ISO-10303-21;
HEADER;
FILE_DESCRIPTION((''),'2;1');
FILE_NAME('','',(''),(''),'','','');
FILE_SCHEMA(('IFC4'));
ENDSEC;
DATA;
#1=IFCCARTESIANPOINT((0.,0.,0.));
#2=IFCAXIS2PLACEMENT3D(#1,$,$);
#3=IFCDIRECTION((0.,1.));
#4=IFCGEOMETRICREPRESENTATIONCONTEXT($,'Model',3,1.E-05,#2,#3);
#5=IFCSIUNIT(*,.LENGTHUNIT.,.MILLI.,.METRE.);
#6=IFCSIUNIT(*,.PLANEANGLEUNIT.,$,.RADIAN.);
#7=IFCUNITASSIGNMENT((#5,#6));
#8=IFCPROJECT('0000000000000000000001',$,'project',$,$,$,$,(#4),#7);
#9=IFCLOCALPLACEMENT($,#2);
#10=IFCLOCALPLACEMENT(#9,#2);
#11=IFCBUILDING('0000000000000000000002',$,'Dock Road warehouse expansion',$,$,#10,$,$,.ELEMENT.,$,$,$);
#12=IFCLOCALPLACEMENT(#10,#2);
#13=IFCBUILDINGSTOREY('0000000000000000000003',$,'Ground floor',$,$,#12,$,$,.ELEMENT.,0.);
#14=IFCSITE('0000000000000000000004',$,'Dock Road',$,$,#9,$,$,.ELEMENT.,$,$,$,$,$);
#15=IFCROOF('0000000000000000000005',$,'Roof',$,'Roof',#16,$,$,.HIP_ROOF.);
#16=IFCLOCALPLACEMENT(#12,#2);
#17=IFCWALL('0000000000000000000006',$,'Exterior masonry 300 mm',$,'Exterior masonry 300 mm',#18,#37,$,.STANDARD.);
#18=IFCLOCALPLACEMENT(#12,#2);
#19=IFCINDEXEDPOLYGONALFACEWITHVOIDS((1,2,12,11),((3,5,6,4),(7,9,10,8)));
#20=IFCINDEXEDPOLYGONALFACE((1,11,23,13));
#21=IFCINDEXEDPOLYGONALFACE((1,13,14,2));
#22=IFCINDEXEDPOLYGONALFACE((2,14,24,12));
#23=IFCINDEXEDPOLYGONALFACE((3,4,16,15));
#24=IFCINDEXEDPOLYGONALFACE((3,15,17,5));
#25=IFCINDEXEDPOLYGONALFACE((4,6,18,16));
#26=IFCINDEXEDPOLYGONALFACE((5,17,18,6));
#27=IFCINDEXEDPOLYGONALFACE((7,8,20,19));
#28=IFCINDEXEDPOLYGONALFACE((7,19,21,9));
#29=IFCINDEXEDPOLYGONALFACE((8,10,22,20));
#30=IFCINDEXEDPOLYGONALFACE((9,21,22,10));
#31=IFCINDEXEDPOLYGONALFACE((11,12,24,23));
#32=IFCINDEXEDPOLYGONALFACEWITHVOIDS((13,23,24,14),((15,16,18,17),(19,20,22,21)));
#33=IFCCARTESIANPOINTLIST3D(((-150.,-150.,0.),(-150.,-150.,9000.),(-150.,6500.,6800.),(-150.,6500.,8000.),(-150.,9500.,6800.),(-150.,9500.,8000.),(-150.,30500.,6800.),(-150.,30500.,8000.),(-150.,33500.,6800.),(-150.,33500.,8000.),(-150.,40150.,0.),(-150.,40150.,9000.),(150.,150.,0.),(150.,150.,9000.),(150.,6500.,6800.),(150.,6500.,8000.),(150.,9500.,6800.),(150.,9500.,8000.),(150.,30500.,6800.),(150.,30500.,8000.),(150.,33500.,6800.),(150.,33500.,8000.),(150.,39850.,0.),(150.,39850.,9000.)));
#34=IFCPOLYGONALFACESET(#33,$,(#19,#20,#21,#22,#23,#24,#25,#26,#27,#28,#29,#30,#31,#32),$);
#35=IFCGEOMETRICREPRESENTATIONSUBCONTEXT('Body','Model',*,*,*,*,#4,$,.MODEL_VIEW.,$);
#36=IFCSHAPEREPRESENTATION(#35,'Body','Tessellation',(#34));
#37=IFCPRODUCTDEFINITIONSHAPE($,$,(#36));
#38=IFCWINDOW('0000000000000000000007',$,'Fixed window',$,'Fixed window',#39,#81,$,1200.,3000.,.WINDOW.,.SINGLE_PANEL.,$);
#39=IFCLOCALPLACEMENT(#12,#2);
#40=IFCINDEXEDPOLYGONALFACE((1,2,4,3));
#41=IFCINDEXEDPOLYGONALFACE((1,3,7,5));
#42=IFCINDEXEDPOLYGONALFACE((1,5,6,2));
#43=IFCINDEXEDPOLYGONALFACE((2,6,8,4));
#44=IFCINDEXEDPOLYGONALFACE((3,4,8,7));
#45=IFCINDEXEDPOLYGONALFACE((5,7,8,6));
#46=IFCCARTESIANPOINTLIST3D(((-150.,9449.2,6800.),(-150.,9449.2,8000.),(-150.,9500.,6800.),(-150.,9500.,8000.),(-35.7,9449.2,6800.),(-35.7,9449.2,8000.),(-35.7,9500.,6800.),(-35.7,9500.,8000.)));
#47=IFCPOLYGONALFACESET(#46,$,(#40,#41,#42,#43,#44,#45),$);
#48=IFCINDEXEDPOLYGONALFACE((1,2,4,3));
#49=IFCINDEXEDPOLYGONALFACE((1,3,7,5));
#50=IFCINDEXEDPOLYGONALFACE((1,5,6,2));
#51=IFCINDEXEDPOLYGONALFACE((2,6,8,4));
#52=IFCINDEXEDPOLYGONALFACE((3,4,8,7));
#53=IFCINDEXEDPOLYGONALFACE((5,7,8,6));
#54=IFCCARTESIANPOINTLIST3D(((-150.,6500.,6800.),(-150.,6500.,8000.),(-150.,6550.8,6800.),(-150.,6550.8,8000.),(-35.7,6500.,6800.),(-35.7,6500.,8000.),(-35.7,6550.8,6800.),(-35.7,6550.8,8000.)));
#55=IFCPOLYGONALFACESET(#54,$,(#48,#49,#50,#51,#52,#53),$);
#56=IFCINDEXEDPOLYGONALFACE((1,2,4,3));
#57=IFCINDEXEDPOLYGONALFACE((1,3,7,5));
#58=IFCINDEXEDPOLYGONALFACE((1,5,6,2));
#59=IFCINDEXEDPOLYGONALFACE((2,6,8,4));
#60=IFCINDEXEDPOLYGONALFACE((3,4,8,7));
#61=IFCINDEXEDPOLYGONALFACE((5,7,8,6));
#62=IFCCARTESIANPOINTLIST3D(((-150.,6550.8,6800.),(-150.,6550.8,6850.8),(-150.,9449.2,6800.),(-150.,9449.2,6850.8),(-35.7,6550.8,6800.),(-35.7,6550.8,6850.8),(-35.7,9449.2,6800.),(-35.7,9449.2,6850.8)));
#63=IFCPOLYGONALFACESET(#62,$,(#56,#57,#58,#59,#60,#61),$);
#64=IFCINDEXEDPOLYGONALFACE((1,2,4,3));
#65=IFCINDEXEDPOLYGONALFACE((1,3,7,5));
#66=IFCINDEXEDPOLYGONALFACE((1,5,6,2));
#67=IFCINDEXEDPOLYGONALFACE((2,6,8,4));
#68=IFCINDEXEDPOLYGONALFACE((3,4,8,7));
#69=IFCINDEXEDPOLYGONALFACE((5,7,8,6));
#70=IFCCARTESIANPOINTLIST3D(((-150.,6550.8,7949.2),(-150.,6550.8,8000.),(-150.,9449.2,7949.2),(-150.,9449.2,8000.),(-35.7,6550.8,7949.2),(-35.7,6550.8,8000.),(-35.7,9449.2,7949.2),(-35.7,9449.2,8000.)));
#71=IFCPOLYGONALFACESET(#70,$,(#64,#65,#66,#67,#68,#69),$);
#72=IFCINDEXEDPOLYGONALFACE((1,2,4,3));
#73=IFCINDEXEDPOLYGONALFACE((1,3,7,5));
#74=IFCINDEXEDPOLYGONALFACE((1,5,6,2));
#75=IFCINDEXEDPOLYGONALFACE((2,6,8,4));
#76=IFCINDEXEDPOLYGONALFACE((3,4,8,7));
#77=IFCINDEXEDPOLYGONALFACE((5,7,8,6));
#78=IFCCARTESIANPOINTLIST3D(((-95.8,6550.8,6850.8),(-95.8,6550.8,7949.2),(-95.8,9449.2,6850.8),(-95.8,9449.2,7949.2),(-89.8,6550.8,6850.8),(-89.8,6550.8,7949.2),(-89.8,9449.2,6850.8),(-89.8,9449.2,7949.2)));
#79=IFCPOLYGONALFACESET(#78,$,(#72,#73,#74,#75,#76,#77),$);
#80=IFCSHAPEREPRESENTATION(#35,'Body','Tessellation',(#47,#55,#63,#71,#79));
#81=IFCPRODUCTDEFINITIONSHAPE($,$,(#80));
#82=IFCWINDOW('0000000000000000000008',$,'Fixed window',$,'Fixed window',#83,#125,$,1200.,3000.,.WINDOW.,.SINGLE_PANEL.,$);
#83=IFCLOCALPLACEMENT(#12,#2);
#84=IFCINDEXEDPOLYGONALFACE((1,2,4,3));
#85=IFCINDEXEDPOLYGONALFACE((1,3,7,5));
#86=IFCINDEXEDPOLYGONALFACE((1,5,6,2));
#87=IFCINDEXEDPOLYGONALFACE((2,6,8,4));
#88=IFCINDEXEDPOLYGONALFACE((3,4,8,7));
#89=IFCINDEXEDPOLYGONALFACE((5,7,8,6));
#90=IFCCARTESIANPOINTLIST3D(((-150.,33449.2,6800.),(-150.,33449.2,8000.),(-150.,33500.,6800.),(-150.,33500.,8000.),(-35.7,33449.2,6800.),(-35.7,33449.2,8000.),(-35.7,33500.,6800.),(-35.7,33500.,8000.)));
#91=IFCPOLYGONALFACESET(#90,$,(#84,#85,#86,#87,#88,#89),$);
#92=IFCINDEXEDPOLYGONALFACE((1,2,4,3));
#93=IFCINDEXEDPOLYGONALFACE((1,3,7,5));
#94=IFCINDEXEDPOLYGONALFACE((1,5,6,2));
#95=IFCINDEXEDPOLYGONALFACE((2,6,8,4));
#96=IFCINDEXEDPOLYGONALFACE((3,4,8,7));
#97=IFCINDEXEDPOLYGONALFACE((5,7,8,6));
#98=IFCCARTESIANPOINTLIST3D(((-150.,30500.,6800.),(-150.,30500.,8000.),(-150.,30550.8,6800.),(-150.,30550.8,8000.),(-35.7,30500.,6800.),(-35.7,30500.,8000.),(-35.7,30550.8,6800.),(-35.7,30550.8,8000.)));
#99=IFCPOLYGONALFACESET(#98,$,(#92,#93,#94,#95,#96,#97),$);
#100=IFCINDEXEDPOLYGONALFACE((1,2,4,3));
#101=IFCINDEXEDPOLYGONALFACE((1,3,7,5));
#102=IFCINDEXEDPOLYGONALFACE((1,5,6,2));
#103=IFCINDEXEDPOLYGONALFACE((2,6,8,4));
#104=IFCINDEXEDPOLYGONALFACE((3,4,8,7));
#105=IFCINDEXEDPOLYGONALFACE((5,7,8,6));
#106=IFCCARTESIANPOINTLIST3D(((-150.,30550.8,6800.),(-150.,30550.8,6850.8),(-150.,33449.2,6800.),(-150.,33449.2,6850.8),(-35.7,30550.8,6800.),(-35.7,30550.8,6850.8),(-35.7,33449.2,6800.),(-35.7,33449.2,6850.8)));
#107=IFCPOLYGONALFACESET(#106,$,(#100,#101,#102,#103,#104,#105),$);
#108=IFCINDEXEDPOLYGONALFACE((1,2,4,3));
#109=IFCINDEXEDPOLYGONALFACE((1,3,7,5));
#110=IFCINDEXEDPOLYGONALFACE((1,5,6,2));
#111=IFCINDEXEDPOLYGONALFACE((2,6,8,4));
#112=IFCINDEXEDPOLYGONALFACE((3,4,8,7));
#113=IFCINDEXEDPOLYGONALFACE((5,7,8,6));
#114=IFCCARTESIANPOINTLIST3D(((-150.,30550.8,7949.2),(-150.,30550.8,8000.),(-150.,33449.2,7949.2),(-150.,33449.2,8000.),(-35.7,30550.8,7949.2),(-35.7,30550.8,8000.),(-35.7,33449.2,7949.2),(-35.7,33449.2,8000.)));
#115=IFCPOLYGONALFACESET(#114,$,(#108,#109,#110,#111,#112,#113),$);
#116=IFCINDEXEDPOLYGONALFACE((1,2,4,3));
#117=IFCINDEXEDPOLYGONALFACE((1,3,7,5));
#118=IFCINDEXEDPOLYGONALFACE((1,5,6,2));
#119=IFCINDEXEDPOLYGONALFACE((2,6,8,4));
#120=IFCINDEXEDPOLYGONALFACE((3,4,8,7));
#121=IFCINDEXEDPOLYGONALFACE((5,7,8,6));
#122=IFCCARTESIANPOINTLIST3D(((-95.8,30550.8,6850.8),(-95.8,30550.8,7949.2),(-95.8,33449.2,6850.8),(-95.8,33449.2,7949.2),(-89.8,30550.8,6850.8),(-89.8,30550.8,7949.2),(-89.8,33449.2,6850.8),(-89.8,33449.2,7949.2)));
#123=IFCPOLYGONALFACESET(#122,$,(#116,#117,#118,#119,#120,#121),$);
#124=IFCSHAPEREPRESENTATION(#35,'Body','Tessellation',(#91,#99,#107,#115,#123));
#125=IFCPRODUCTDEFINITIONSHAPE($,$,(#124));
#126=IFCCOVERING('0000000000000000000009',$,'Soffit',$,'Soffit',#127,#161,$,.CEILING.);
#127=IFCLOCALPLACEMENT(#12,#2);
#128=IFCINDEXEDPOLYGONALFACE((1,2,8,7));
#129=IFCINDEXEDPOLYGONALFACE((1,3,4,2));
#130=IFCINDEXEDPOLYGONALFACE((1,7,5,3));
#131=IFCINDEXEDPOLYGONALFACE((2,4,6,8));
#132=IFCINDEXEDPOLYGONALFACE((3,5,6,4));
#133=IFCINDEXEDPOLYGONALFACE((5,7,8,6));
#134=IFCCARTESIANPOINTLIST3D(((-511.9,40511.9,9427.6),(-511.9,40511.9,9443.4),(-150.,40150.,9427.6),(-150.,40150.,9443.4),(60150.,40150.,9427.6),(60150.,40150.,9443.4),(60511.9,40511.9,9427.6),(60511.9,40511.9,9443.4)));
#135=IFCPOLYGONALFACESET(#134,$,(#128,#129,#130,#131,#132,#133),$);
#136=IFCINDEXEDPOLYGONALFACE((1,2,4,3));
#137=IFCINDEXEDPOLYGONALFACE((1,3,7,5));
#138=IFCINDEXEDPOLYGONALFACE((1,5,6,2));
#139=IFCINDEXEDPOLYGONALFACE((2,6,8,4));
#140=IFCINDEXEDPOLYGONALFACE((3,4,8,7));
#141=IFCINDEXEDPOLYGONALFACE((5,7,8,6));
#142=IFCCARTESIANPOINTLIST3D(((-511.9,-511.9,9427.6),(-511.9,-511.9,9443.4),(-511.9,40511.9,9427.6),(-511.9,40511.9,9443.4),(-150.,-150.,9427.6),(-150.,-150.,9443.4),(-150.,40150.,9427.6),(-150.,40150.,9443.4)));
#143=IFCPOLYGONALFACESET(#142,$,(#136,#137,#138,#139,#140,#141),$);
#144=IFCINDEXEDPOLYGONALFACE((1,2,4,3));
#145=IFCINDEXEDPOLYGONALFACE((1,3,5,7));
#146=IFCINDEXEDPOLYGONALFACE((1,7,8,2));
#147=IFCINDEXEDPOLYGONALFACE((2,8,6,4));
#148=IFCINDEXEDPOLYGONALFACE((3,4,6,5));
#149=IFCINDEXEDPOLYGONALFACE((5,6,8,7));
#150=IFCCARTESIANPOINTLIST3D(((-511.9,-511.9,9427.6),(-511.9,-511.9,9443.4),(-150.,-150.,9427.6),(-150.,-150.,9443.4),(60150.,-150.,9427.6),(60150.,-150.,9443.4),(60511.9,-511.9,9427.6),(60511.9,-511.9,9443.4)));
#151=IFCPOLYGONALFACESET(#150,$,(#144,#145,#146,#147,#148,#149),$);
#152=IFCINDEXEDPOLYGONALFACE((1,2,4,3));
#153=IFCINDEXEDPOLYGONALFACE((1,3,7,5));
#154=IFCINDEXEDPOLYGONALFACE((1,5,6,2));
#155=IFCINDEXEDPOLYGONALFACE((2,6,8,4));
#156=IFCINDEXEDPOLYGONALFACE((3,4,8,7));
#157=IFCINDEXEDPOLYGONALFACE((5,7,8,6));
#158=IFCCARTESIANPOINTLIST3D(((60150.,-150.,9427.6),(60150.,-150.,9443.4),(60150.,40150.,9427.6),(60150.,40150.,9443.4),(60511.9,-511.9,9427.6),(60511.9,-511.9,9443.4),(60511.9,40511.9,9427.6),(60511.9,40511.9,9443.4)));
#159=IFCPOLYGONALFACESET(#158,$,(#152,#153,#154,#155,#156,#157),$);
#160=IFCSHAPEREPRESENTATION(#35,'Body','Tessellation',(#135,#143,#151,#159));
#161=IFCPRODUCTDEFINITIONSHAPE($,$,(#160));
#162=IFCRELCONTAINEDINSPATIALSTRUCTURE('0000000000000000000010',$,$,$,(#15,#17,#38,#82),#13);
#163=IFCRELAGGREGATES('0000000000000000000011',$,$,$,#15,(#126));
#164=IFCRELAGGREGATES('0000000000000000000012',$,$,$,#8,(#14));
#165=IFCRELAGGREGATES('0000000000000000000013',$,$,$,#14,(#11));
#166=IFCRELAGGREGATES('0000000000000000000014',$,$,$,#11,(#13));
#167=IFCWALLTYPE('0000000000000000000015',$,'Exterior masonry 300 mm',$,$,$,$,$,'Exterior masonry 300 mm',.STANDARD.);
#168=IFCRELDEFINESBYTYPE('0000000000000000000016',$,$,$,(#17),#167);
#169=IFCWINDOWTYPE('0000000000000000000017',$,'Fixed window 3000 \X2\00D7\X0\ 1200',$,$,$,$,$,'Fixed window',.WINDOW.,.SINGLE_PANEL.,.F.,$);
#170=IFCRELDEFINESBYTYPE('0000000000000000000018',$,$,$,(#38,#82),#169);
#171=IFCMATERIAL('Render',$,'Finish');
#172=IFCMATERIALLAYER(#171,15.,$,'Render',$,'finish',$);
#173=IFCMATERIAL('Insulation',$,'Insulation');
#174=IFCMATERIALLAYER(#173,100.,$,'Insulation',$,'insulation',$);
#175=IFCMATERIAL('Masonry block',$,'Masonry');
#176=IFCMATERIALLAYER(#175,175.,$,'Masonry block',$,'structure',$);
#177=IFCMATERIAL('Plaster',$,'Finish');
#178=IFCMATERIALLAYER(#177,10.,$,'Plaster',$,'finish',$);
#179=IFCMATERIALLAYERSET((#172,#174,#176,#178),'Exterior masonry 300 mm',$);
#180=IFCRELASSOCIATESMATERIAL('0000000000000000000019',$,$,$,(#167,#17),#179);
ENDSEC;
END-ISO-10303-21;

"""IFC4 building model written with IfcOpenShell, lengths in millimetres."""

from ifc_helpers import new_model, si_unit, direction, frame, origin, origin_with_axes, place, context, subcontext, project, spatial, polyline, outline, extrude, material, layer, layer_set, layer_usage, type_object, element, fill, aggregate, save


model = new_model("IFC4")

# Units and contexts
model_context = context("Model", 3, precision=1e-05, world=origin(), true_north=direction((0.0, 1.0)))
body_context = subcontext(model_context, "Body", "Model", "MODEL_VIEW")
ifc_project = project(units=[si_unit("LENGTHUNIT", "METRE", prefix="MILLI"), si_unit("PLANEANGLEUNIT", "RADIAN")], contexts=[model_context])

# Site, building, storey
site_placement = place(None, origin())
site = spatial("IfcSite", under=ifc_project, at=site_placement, Name="Dock Road", CompositionType="ELEMENT")
building_placement = place(site_placement, origin())
building = spatial("IfcBuilding", under=site, at=building_placement, Name="Dock Road warehouse expansion", CompositionType="ELEMENT")
storey_placement = place(building_placement, origin())
storey = spatial("IfcBuildingStorey", under=building, at=storey_placement, Name="Ground floor", CompositionType="ELEMENT", Elevation=0.0)

# Roof
roof_placement = place(storey_placement, origin_with_axes())
roof = element("IfcRoof", 1, at=roof_placement, inside=storey, Name="Roof", ObjectType="Roof", PredefinedType="HIP_ROOF")

# Shared definitions
ifc_material_1 = material(Name="Render", Category="Finish")
ifc_layer_1 = layer(ifc_material_1, 15.0, Name="Render", Category="finish")
ifc_material_2 = material(Name="Insulation", Category="Insulation")
ifc_layer_2 = layer(ifc_material_2, 100.0, Name="Insulation", Category="insulation")
ifc_material_3 = material(Name="Masonry block", Category="Masonry")
ifc_layer_3 = layer(ifc_material_3, 175.0, Name="Masonry block", Category="structure")
ifc_material_4 = material(Name="Plaster", Category="Finish")
ifc_layer_4 = layer(ifc_material_4, 10.0, Name="Plaster", Category="finish")
ifc_layer_set = layer_set([ifc_layer_1, ifc_layer_2, ifc_layer_3, ifc_layer_4], Name="Exterior masonry 300 mm")
wall_type = type_object("IfcWallType", Name="Exterior masonry 300 mm", ElementType="Exterior masonry 300 mm", PredefinedType="STANDARD", material=ifc_layer_set)
window_type = type_object("IfcWindowType", Name="Fixed window 3000 × 1200", ElementType="Fixed window", ParameterTakesPrecedence=False, PartitioningType="SINGLE_PANEL", PredefinedType="WINDOW")

# Wall, openings, windows
ifc_layer_usage_1 = layer_usage(ifc_layer_set, "AXIS2", "POSITIVE", -150.0)
wall_1_placement = place(storey_placement, frame((0.0, 40000.0, 0.0), z_axis=(0.0, 0.0, 1.0), x_axis=(0.0, -1.0, 0.0)))
wall_1 = element("IfcWall", 2, at=wall_1_placement, inside=storey, type_object=wall_type, material=ifc_layer_usage_1, Name="Exterior masonry 300 mm", ObjectType="Exterior masonry 300 mm", PredefinedType="STANDARD", context=body_context, shape_type="SweptSolid", body=[
    extrude(outline(polyline([(-150.0, -150.0), (40150.0, -150.0), (39850.0, 150.0), (150.0, 150.0), (-150.0, -150.0)])), origin(), (0.0, 0.0, 1.0), 9000.0),
])
opening_1_placement = place(wall_1_placement, frame((30500.0, 0.0, 6800.0), z_axis=(0.0, 0.0, 1.0), x_axis=(1.0, 0.0, 0.0)))
opening_1 = element("IfcOpeningElement", 3, at=opening_1_placement, cuts=wall_1, PredefinedType="OPENING", context=body_context, shape_type="SweptSolid", body=[
    extrude(outline(polyline([(0.0, -160.0), (3000.0, -160.0), (3000.0, 160.0), (0.0, 160.0), (0.0, -160.0)])), origin(), (0.0, 0.0, 1.0), 1200.0),
])
opening_2_placement = place(wall_1_placement, frame((6500.0, 0.0, 6800.0), z_axis=(0.0, 0.0, 1.0), x_axis=(1.0, 0.0, 0.0)))
opening_2 = element("IfcOpeningElement", 4, at=opening_2_placement, cuts=wall_1, PredefinedType="OPENING", context=body_context, shape_type="SweptSolid", body=[
    extrude(outline(polyline([(0.0, -160.0), (3000.0, -160.0), (3000.0, 160.0), (0.0, 160.0), (0.0, -160.0)])), origin(), (0.0, 0.0, 1.0), 1200.0),
])
window_1_placement = place(opening_1_placement, origin_with_axes())
window_1 = element("IfcWindow", 5, at=window_1_placement, inside=storey, type_object=window_type, Name="Fixed window", ObjectType="Fixed window", OverallHeight=1200.0, OverallWidth=3000.0, PartitioningType="SINGLE_PANEL", PredefinedType="WINDOW", context=body_context, shape_type="SweptSolid", body=[
    extrude(outline(polyline([(0.0, -150.0), (50.8, -150.0), (50.8, -35.7), (0.0, -35.7), (0.0, -150.0)])), origin(), (0.0, 0.0, 1.0), 1200.0),
    extrude(outline(polyline([(2949.2, -150.0), (3000.0, -150.0), (3000.0, -35.7), (2949.2, -35.7), (2949.2, -150.0)])), origin(), (0.0, 0.0, 1.0), 1200.0),
    extrude(outline(polyline([(50.8, -150.0), (2949.2, -150.0), (2949.2, -35.7), (50.8, -35.7), (50.8, -150.0)])), origin(), (0.0, 0.0, 1.0), 50.8),
    extrude(outline(polyline([(50.8, -150.0), (2949.2, -150.0), (2949.2, -35.7), (50.8, -35.7), (50.8, -150.0)])), frame((0.0, 0.0, 1149.2)), (0.0, 0.0, 1.0), 50.8),
    extrude(outline(polyline([(50.8, -95.8), (2949.2, -95.8), (2949.2, -89.8), (50.8, -89.8), (50.8, -95.8)])), frame((0.0, 0.0, 50.8)), (0.0, 0.0, 1.0), 1098.4),
])
fill(opening_1, window_1)
window_2_placement = place(opening_2_placement, origin_with_axes())
window_2 = element("IfcWindow", 6, at=window_2_placement, inside=storey, type_object=window_type, Name="Fixed window", ObjectType="Fixed window", OverallHeight=1200.0, OverallWidth=3000.0, PartitioningType="SINGLE_PANEL", PredefinedType="WINDOW", context=body_context, shape_type="SweptSolid", body=[
    extrude(outline(polyline([(0.0, -150.0), (50.8, -150.0), (50.8, -35.7), (0.0, -35.7), (0.0, -150.0)])), origin(), (0.0, 0.0, 1.0), 1200.0),
    extrude(outline(polyline([(2949.2, -150.0), (3000.0, -150.0), (3000.0, -35.7), (2949.2, -35.7), (2949.2, -150.0)])), origin(), (0.0, 0.0, 1.0), 1200.0),
    extrude(outline(polyline([(50.8, -150.0), (2949.2, -150.0), (2949.2, -35.7), (50.8, -35.7), (50.8, -150.0)])), origin(), (0.0, 0.0, 1.0), 50.8),
    extrude(outline(polyline([(50.8, -150.0), (2949.2, -150.0), (2949.2, -35.7), (50.8, -35.7), (50.8, -150.0)])), frame((0.0, 0.0, 1149.2)), (0.0, 0.0, 1.0), 50.8),
    extrude(outline(polyline([(50.8, -95.8), (2949.2, -95.8), (2949.2, -89.8), (50.8, -89.8), (50.8, -95.8)])), frame((0.0, 0.0, 50.8)), (0.0, 0.0, 1.0), 1098.4),
])
fill(opening_2, window_2)

# Covering
covering_placement = place(storey_placement, origin_with_axes())
covering = element("IfcCovering", 7, at=covering_placement, Name="Soffit", ObjectType="Soffit", PredefinedType="CEILING", context=body_context, shape_type="SweptSolid", body=[
    extrude(outline(polyline([(60150.0, 40150.0), (-150.0, 40150.0), (-511.9, 40511.9), (60511.9, 40511.9), (60150.0, 40150.0)])), frame((0.0, 0.0, 9427.6), z_axis=(0.0, 0.0, 1.0), x_axis=(1.0, 0.0, 0.0)), (0.0, 0.0, 1.0), 15.9),
    extrude(outline(polyline([(-150.0, 40150.0), (-150.0, -150.0), (-511.9, -511.9), (-511.9, 40511.9), (-150.0, 40150.0)])), frame((0.0, 0.0, 9427.6), z_axis=(0.0, 0.0, 1.0), x_axis=(1.0, 0.0, 0.0)), (0.0, 0.0, 1.0), 15.9),
    extrude(outline(polyline([(-150.0, -150.0), (60150.0, -150.0), (60511.9, -511.9), (-511.9, -511.9), (-150.0, -150.0)])), frame((0.0, 0.0, 9427.6), z_axis=(0.0, 0.0, 1.0), x_axis=(1.0, 0.0, 0.0)), (0.0, 0.0, 1.0), 15.9),
    extrude(outline(polyline([(60150.0, -150.0), (60150.0, 40150.0), (60511.9, 40511.9), (60511.9, -511.9), (60150.0, -150.0)])), frame((0.0, 0.0, 9427.6), z_axis=(0.0, 0.0, 1.0), x_axis=(1.0, 0.0, 0.0)), (0.0, 0.0, 1.0), 15.9),
])
aggregate(roof, [covering])

save(model, "model.ifc")
